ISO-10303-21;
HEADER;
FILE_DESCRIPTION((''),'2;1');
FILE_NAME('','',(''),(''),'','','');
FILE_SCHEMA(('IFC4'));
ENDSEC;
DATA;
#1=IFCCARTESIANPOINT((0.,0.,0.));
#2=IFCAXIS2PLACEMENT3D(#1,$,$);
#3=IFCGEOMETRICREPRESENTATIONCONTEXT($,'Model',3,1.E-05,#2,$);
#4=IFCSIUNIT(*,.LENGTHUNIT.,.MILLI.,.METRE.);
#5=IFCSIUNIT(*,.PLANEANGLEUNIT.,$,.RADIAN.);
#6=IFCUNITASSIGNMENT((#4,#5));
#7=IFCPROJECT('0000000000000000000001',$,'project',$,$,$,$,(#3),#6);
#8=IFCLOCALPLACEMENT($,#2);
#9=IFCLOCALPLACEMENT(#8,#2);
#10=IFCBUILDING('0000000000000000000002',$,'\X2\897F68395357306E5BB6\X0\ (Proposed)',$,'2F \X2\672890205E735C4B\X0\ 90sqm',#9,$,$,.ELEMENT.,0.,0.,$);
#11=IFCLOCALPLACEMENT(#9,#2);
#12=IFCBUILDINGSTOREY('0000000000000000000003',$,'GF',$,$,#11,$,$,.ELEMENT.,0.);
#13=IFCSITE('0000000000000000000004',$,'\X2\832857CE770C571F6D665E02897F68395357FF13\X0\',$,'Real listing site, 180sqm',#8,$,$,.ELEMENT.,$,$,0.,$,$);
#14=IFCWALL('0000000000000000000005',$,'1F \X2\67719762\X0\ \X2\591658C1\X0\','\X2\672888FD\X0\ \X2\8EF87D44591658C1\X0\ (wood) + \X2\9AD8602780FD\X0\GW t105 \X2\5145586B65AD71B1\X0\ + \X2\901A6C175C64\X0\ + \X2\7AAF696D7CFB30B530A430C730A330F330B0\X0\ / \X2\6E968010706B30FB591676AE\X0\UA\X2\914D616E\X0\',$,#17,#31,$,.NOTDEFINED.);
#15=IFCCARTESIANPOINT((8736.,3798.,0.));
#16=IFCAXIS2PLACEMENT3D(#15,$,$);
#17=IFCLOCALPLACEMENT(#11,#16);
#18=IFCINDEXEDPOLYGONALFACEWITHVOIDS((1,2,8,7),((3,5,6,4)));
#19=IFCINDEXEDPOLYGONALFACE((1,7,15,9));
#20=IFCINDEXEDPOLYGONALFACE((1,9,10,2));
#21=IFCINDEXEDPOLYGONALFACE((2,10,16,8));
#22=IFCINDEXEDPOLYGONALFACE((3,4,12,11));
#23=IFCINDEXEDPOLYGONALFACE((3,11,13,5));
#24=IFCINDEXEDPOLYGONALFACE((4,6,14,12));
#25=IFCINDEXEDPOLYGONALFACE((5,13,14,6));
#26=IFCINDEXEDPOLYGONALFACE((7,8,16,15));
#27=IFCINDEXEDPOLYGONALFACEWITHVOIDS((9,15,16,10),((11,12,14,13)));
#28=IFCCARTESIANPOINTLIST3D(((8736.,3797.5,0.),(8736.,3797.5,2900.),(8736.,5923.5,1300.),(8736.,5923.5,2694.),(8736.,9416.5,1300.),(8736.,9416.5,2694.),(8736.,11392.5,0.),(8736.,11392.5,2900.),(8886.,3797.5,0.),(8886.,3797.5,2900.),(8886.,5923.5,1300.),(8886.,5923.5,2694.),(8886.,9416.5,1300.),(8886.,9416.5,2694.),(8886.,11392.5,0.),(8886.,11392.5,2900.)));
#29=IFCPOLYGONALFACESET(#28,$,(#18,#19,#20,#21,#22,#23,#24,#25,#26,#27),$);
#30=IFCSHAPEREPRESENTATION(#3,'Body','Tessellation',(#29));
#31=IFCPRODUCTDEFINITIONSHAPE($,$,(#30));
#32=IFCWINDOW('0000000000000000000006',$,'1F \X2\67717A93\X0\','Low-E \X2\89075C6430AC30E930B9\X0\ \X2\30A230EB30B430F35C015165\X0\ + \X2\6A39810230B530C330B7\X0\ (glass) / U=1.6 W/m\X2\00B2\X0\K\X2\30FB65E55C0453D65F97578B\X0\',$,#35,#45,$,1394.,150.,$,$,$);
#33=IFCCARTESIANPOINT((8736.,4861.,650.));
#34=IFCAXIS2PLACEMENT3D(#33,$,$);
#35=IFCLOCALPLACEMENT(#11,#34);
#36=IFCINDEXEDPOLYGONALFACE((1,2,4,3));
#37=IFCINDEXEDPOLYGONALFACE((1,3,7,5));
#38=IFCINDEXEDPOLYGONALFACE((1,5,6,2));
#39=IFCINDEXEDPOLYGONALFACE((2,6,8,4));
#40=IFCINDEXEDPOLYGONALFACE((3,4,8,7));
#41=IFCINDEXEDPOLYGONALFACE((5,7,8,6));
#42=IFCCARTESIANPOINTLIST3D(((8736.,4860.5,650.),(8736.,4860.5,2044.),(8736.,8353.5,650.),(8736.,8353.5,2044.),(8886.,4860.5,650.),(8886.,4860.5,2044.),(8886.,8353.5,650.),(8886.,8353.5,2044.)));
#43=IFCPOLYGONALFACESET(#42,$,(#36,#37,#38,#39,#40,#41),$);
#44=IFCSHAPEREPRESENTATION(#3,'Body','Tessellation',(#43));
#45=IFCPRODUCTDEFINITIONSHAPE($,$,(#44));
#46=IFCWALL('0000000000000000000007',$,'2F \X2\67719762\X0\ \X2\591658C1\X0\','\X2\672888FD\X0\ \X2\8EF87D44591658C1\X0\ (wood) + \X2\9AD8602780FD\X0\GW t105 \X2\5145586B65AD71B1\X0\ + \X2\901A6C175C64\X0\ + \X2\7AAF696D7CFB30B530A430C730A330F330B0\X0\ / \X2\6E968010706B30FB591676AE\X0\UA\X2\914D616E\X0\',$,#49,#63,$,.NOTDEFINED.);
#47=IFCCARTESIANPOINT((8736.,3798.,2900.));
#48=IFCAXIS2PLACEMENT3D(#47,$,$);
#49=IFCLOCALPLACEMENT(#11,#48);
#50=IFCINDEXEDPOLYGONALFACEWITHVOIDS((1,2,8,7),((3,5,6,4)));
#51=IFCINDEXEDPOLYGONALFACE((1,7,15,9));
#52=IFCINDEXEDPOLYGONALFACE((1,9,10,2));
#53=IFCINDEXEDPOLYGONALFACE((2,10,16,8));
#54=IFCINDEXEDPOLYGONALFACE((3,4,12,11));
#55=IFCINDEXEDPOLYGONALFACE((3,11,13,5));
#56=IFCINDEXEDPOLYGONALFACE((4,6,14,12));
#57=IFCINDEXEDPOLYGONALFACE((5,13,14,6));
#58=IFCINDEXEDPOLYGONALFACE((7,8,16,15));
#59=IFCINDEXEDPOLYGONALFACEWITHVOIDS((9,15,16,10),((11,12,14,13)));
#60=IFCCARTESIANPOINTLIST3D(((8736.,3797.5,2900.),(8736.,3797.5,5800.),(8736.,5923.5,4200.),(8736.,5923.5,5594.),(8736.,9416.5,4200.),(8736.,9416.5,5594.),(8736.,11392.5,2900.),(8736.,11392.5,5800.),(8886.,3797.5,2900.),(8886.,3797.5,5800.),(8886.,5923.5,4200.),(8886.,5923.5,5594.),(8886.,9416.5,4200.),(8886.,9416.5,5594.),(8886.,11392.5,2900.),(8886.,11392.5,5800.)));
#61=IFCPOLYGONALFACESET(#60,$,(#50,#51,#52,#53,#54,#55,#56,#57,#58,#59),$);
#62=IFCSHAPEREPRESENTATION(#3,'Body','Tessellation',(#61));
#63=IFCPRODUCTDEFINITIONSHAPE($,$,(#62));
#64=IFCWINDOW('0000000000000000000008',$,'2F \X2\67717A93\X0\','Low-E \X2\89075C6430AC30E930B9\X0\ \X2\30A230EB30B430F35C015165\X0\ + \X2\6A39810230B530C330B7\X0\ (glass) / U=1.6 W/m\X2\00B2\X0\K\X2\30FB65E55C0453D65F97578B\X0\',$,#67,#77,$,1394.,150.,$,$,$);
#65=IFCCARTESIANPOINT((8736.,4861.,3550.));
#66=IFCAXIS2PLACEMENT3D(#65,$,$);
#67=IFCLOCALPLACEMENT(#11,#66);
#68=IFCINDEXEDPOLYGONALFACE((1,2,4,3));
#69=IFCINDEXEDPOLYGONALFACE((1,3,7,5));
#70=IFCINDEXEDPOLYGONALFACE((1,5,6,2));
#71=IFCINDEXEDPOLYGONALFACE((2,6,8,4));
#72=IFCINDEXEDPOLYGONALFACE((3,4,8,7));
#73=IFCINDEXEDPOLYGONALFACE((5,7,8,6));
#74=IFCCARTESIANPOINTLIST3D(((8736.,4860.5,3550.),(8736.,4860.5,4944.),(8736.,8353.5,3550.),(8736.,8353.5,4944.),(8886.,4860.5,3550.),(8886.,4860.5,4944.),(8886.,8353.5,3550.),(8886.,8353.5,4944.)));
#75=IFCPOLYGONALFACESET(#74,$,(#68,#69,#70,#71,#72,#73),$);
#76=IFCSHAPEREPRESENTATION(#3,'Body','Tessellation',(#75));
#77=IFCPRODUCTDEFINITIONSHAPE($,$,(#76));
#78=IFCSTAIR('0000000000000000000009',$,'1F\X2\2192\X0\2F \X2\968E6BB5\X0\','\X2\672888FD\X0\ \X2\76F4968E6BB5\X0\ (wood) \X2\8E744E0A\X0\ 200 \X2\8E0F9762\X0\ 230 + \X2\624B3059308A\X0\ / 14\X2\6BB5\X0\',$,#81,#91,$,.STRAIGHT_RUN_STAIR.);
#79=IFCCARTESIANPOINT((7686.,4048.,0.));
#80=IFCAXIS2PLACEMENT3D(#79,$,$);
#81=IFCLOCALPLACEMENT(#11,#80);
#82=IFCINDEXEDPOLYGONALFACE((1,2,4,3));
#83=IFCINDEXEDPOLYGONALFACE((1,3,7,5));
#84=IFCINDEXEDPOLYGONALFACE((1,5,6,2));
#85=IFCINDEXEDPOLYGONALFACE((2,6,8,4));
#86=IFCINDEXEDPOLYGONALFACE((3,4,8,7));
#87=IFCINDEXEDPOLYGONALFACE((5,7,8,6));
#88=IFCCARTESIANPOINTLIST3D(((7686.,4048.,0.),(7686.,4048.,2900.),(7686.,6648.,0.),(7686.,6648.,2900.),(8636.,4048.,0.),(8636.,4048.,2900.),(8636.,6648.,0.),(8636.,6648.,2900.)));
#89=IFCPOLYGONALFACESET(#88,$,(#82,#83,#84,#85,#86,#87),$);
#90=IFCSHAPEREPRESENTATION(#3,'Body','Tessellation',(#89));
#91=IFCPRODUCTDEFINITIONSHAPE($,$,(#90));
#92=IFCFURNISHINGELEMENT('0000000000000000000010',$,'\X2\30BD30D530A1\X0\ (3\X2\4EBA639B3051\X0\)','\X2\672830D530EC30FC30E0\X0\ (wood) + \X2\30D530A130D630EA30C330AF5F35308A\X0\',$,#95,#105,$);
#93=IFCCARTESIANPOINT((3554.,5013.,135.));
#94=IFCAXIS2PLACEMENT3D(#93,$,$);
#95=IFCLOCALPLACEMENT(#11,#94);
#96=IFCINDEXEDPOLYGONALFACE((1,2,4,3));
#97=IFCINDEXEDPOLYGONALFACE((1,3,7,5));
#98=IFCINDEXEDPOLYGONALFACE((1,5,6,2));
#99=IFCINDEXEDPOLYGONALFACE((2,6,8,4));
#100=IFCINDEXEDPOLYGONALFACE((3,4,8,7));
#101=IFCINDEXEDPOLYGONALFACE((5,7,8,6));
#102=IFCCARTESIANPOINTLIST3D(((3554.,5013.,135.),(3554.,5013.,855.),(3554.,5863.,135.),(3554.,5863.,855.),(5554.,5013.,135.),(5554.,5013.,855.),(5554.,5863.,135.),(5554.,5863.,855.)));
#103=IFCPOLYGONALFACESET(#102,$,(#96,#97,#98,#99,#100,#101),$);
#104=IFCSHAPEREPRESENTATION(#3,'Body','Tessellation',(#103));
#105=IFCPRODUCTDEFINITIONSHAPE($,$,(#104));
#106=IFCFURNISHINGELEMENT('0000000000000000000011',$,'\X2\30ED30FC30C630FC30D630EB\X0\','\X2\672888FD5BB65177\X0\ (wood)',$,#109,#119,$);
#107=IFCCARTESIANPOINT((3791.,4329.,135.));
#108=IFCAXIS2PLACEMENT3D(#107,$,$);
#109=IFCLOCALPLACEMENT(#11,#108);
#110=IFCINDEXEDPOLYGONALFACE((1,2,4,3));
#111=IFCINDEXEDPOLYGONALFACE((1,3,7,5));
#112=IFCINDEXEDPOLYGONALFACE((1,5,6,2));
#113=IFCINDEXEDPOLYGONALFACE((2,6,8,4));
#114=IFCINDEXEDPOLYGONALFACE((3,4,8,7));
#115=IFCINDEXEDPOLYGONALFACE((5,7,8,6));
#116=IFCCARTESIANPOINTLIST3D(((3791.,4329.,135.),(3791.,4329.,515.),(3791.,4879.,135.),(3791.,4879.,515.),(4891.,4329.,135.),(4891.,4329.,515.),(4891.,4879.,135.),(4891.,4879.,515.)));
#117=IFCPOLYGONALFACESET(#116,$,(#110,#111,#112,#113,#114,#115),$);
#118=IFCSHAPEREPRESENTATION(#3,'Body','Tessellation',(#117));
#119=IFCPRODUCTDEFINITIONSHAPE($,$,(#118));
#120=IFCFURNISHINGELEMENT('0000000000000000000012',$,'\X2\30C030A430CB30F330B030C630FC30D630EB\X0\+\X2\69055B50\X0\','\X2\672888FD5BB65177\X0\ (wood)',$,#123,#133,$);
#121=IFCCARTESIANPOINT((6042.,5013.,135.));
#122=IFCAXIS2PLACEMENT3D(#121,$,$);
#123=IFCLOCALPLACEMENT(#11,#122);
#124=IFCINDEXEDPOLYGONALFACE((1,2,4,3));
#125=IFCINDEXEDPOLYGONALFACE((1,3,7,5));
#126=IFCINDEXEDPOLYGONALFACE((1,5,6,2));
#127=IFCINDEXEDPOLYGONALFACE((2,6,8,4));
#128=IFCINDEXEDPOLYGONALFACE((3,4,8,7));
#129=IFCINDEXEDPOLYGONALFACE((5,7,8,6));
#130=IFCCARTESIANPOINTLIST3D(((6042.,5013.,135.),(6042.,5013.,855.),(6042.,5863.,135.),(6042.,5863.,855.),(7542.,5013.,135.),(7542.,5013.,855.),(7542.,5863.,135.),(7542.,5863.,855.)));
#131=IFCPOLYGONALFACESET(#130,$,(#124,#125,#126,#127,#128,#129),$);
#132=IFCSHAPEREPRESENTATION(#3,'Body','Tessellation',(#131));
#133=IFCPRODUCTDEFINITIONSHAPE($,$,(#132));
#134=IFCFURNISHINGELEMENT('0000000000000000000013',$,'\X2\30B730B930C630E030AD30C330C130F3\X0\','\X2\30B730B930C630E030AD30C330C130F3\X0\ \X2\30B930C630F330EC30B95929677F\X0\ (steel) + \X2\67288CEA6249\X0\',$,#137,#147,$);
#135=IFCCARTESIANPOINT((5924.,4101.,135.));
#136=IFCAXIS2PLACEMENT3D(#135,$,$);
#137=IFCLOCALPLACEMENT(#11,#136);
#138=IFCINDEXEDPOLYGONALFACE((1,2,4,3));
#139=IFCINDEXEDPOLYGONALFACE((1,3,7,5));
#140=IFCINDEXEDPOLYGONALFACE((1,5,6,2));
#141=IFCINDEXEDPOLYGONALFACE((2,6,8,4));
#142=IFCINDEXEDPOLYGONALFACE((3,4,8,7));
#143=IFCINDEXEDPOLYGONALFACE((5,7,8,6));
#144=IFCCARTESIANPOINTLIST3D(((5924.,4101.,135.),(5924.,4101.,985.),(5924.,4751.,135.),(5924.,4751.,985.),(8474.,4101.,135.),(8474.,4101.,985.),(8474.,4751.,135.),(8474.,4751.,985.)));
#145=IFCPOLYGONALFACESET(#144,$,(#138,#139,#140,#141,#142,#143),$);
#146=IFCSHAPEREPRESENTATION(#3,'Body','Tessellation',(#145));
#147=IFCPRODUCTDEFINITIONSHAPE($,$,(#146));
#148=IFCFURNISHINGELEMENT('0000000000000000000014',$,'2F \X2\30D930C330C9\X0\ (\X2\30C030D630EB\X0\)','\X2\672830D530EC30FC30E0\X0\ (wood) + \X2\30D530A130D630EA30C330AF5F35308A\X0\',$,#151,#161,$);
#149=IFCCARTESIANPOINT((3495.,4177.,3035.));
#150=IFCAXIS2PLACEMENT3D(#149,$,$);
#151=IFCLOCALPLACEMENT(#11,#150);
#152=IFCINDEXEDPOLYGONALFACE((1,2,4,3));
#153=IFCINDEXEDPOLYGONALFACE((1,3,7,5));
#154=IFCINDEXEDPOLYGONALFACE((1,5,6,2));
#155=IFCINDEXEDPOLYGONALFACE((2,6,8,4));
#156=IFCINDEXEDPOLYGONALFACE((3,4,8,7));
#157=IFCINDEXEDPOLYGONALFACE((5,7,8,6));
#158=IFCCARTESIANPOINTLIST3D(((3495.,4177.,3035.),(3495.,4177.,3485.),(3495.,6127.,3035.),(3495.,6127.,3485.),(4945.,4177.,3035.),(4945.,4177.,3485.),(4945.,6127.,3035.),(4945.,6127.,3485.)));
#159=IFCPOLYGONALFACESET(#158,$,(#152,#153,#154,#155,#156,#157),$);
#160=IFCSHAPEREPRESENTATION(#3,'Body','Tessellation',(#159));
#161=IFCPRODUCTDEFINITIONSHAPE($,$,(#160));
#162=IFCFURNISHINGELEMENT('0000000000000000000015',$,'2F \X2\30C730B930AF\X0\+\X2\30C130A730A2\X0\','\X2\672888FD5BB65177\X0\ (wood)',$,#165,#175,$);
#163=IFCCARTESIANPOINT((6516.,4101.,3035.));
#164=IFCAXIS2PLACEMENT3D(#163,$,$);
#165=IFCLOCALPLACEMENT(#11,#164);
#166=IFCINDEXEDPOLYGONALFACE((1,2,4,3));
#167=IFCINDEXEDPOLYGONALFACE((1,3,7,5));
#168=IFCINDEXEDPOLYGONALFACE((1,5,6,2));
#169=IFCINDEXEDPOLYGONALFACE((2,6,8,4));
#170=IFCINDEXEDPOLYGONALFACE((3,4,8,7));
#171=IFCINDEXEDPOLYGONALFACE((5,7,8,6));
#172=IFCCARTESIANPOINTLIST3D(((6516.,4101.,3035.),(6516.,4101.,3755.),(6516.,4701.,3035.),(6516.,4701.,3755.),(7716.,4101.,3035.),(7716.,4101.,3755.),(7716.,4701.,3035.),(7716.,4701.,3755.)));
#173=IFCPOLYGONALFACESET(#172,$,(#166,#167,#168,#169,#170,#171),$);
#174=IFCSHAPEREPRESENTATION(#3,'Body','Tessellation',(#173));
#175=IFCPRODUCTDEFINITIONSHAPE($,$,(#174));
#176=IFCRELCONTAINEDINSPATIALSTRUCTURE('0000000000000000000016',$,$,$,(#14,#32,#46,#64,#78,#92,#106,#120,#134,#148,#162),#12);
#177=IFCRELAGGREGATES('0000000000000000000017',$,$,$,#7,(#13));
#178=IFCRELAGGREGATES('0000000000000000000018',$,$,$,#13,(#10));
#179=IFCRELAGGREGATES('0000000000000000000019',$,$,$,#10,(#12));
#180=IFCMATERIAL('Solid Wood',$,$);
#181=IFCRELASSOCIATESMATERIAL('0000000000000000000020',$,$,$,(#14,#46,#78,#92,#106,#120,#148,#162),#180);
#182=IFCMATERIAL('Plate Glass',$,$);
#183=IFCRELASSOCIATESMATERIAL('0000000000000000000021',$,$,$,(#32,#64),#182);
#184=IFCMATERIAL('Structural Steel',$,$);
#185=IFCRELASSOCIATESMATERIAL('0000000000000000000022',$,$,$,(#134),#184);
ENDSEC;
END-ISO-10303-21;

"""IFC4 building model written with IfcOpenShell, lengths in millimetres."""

from ifc_helpers import new_model, si_unit, frame, frame_2d, origin, place, context, project, spatial, rectangle, extrude, material, element, fill, save


model = new_model("IFC4")

# Units and contexts
model_context = context("Model", 3, precision=1e-05, world=origin())
ifc_project = project(units=[si_unit("LENGTHUNIT", "METRE", prefix="MILLI"), si_unit("PLANEANGLEUNIT", "RADIAN")], contexts=[model_context])

# Site, building, storey
site_placement = place(None, origin())
site = spatial("IfcSite", under=ifc_project, at=site_placement, Name="茨城県土浦市西根南３", ObjectType="Real listing site, 180sqm", CompositionType="ELEMENT", RefElevation=0.0)
building_placement = place(site_placement, origin())
building = spatial("IfcBuilding", under=site, at=building_placement, Name="西根南の家 (Proposed)", ObjectType="2F 木造平屋 90sqm", CompositionType="ELEMENT", ElevationOfRefHeight=0.0, ElevationOfTerrain=0.0)
storey_placement = place(building_placement, origin())
storey = spatial("IfcBuildingStorey", under=building, at=storey_placement, Name="GF", CompositionType="ELEMENT", Elevation=0.0)

# Wall, opening, window
ifc_material_1 = material(Name="Solid Wood")
wall_1_placement = place(storey_placement, frame((8736.0, 3798.0, 0.0)))
wall_1 = element("IfcWall", 1, at=wall_1_placement, inside=storey, material=ifc_material_1, Name="1F 東面 外壁", Description="木製 軸組外壁 (wood) + 高性能GW t105 充填断熱 + 通気層 + 窯業系サイディング / 準耐火・外皮UA配慮", PredefinedType="NOTDEFINED", context=model_context, shape_type="SweptSolid", body=[
    extrude(rectangle(XDim=150.0, YDim=7595.0, at=frame_2d((75.0, 3797.0))), frame((8736.0, 3798.0, 0.0)), (0.0, 0.0, 1.0), 2900.0),
])
opening_1_placement = place(storey_placement, frame((8736.0, 4861.0, 650.0)))
opening_1 = element("IfcOpeningElement", 2, at=opening_1_placement, cuts=wall_1, PredefinedType="NOTDEFINED", context=model_context, shape_type="SweptSolid", body=[
    extrude(rectangle(XDim=150.0, YDim=3493.0, at=frame_2d((75.0, 1746.0))), frame((8736.0, 4861.0, 650.0)), (0.0, 0.0, 1.0), 1394.0),
])
ifc_material_2 = material(Name="Plate Glass")
window_1_placement = place(storey_placement, frame((8736.0, 4861.0, 650.0)))
window_1 = element("IfcWindow", 3, at=window_1_placement, inside=storey, material=ifc_material_2, Name="1F 東窓", Description="Low-E 複層ガラス アルゴン封入 + 樹脂サッシ (glass) / U=1.6 W/m²K・日射取得型", OverallHeight=1394.0, OverallWidth=150.0, context=model_context, shape_type="SweptSolid", body=[
    extrude(rectangle(XDim=150.0, YDim=3493.0, at=frame_2d((75.0, 1746.0))), frame((8736.0, 4861.0, 650.0)), (0.0, 0.0, 1.0), 1394.0),
])
fill(opening_1, window_1)

# Wall, opening, window
wall_2_placement = place(storey_placement, frame((8736.0, 3798.0, 2900.0)))
wall_2 = element("IfcWall", 4, at=wall_2_placement, inside=storey, material=ifc_material_1, Name="2F 東面 外壁", Description="木製 軸組外壁 (wood) + 高性能GW t105 充填断熱 + 通気層 + 窯業系サイディング / 準耐火・外皮UA配慮", PredefinedType="NOTDEFINED", context=model_context, shape_type="SweptSolid", body=[
    extrude(rectangle(XDim=150.0, YDim=7595.0, at=frame_2d((75.0, 3797.0))), frame((8736.0, 3798.0, 2900.0)), (0.0, 0.0, 1.0), 2900.0),
])
opening_2_placement = place(storey_placement, frame((8736.0, 4861.0, 3550.0)))
opening_2 = element("IfcOpeningElement", 5, at=opening_2_placement, cuts=wall_2, PredefinedType="NOTDEFINED", context=model_context, shape_type="SweptSolid", body=[
    extrude(rectangle(XDim=150.0, YDim=3493.0, at=frame_2d((75.0, 1746.0))), frame((8736.0, 4861.0, 3550.0)), (0.0, 0.0, 1.0), 1394.0),
])
window_2_placement = place(storey_placement, frame((8736.0, 4861.0, 3550.0)))
window_2 = element("IfcWindow", 6, at=window_2_placement, inside=storey, material=ifc_material_2, Name="2F 東窓", Description="Low-E 複層ガラス アルゴン封入 + 樹脂サッシ (glass) / U=1.6 W/m²K・日射取得型", OverallHeight=1394.0, OverallWidth=150.0, context=model_context, shape_type="SweptSolid", body=[
    extrude(rectangle(XDim=150.0, YDim=3493.0, at=frame_2d((75.0, 1746.0))), frame((8736.0, 4861.0, 3550.0)), (0.0, 0.0, 1.0), 1394.0),
])
fill(opening_2, window_2)

# Stair
stair_placement = place(storey_placement, frame((7686.0, 4048.0, 0.0)))
element("IfcStair", 7, at=stair_placement, inside=storey, material=ifc_material_1, Name="1F→2F 階段", Description="木製 直階段 (wood) 蹴上 200 踏面 230 + 手すり / 14段", PredefinedType="STRAIGHT_RUN_STAIR", context=model_context, shape_type="SweptSolid", body=[
    extrude(rectangle(XDim=950.0, YDim=2600.0, at=frame_2d((475.0, 1300.0))), frame((7686.0, 4048.0, 0.0)), (0.0, 0.0, 1.0), 2900.0),
])

# Furnishing elements
furnishing_1_placement = place(storey_placement, frame((3554.0, 5013.0, 135.0)))
element("IfcFurnishingElement", 8, at=furnishing_1_placement, inside=storey, material=ifc_material_1, Name="ソファ (3人掛け)", Description="木フレーム (wood) + ファブリック張り", context=model_context, shape_type="SweptSolid", body=[
    extrude(rectangle(XDim=2000.0, YDim=850.0, at=frame_2d((1000.0, 425.0))), frame((3554.0, 5013.0, 135.0)), (0.0, 0.0, 1.0), 720.0),
])
furnishing_2_placement = place(storey_placement, frame((3791.0, 4329.0, 135.0)))
element("IfcFurnishingElement", 9, at=furnishing_2_placement, inside=storey, material=ifc_material_1, Name="ローテーブル", Description="木製家具 (wood)", context=model_context, shape_type="SweptSolid", body=[
    extrude(rectangle(XDim=1100.0, YDim=550.0, at=frame_2d((550.0, 275.0))), frame((3791.0, 4329.0, 135.0)), (0.0, 0.0, 1.0), 380.0),
])
furnishing_3_placement = place(storey_placement, frame((6042.0, 5013.0, 135.0)))
element("IfcFurnishingElement", 10, at=furnishing_3_placement, inside=storey, material=ifc_material_1, Name="ダイニングテーブル+椅子", Description="木製家具 (wood)", context=model_context, shape_type="SweptSolid", body=[
    extrude(rectangle(XDim=1500.0, YDim=850.0, at=frame_2d((750.0, 425.0))), frame((6042.0, 5013.0, 135.0)), (0.0, 0.0, 1.0), 720.0),
])
ifc_material_3 = material(Name="Structural Steel")
furnishing_4_placement = place(storey_placement, frame((5924.0, 4101.0, 135.0)))
element("IfcFurnishingElement", 11, at=furnishing_4_placement, inside=storey, material=ifc_material_3, Name="システムキッチン", Description="システムキッチン ステンレス天板 (steel) + 木質扉", context=model_context, shape_type="SweptSolid", body=[
    extrude(rectangle(XDim=2550.0, YDim=650.0, at=frame_2d((1275.0, 325.0))), frame((5924.0, 4101.0, 135.0)), (0.0, 0.0, 1.0), 850.0),
])
furnishing_5_placement = place(storey_placement, frame((3495.0, 4177.0, 3035.0)))
element("IfcFurnishingElement", 12, at=furnishing_5_placement, inside=storey, material=ifc_material_1, Name="2F ベッド (ダブル)", Description="木フレーム (wood) + ファブリック張り", context=model_context, shape_type="SweptSolid", body=[
    extrude(rectangle(XDim=1450.0, YDim=1950.0, at=frame_2d((725.0, 975.0))), frame((3495.0, 4177.0, 3035.0)), (0.0, 0.0, 1.0), 450.0),
])
furnishing_6_placement = place(storey_placement, frame((6516.0, 4101.0, 3035.0)))
element("IfcFurnishingElement", 13, at=furnishing_6_placement, inside=storey, material=ifc_material_1, Name="2F デスク+チェア", Description="木製家具 (wood)", context=model_context, shape_type="SweptSolid", body=[
    extrude(rectangle(XDim=1200.0, YDim=600.0, at=frame_2d((600.0, 300.0))), frame((6516.0, 4101.0, 3035.0)), (0.0, 0.0, 1.0), 720.0),
])

save(model, "model.ifc")
